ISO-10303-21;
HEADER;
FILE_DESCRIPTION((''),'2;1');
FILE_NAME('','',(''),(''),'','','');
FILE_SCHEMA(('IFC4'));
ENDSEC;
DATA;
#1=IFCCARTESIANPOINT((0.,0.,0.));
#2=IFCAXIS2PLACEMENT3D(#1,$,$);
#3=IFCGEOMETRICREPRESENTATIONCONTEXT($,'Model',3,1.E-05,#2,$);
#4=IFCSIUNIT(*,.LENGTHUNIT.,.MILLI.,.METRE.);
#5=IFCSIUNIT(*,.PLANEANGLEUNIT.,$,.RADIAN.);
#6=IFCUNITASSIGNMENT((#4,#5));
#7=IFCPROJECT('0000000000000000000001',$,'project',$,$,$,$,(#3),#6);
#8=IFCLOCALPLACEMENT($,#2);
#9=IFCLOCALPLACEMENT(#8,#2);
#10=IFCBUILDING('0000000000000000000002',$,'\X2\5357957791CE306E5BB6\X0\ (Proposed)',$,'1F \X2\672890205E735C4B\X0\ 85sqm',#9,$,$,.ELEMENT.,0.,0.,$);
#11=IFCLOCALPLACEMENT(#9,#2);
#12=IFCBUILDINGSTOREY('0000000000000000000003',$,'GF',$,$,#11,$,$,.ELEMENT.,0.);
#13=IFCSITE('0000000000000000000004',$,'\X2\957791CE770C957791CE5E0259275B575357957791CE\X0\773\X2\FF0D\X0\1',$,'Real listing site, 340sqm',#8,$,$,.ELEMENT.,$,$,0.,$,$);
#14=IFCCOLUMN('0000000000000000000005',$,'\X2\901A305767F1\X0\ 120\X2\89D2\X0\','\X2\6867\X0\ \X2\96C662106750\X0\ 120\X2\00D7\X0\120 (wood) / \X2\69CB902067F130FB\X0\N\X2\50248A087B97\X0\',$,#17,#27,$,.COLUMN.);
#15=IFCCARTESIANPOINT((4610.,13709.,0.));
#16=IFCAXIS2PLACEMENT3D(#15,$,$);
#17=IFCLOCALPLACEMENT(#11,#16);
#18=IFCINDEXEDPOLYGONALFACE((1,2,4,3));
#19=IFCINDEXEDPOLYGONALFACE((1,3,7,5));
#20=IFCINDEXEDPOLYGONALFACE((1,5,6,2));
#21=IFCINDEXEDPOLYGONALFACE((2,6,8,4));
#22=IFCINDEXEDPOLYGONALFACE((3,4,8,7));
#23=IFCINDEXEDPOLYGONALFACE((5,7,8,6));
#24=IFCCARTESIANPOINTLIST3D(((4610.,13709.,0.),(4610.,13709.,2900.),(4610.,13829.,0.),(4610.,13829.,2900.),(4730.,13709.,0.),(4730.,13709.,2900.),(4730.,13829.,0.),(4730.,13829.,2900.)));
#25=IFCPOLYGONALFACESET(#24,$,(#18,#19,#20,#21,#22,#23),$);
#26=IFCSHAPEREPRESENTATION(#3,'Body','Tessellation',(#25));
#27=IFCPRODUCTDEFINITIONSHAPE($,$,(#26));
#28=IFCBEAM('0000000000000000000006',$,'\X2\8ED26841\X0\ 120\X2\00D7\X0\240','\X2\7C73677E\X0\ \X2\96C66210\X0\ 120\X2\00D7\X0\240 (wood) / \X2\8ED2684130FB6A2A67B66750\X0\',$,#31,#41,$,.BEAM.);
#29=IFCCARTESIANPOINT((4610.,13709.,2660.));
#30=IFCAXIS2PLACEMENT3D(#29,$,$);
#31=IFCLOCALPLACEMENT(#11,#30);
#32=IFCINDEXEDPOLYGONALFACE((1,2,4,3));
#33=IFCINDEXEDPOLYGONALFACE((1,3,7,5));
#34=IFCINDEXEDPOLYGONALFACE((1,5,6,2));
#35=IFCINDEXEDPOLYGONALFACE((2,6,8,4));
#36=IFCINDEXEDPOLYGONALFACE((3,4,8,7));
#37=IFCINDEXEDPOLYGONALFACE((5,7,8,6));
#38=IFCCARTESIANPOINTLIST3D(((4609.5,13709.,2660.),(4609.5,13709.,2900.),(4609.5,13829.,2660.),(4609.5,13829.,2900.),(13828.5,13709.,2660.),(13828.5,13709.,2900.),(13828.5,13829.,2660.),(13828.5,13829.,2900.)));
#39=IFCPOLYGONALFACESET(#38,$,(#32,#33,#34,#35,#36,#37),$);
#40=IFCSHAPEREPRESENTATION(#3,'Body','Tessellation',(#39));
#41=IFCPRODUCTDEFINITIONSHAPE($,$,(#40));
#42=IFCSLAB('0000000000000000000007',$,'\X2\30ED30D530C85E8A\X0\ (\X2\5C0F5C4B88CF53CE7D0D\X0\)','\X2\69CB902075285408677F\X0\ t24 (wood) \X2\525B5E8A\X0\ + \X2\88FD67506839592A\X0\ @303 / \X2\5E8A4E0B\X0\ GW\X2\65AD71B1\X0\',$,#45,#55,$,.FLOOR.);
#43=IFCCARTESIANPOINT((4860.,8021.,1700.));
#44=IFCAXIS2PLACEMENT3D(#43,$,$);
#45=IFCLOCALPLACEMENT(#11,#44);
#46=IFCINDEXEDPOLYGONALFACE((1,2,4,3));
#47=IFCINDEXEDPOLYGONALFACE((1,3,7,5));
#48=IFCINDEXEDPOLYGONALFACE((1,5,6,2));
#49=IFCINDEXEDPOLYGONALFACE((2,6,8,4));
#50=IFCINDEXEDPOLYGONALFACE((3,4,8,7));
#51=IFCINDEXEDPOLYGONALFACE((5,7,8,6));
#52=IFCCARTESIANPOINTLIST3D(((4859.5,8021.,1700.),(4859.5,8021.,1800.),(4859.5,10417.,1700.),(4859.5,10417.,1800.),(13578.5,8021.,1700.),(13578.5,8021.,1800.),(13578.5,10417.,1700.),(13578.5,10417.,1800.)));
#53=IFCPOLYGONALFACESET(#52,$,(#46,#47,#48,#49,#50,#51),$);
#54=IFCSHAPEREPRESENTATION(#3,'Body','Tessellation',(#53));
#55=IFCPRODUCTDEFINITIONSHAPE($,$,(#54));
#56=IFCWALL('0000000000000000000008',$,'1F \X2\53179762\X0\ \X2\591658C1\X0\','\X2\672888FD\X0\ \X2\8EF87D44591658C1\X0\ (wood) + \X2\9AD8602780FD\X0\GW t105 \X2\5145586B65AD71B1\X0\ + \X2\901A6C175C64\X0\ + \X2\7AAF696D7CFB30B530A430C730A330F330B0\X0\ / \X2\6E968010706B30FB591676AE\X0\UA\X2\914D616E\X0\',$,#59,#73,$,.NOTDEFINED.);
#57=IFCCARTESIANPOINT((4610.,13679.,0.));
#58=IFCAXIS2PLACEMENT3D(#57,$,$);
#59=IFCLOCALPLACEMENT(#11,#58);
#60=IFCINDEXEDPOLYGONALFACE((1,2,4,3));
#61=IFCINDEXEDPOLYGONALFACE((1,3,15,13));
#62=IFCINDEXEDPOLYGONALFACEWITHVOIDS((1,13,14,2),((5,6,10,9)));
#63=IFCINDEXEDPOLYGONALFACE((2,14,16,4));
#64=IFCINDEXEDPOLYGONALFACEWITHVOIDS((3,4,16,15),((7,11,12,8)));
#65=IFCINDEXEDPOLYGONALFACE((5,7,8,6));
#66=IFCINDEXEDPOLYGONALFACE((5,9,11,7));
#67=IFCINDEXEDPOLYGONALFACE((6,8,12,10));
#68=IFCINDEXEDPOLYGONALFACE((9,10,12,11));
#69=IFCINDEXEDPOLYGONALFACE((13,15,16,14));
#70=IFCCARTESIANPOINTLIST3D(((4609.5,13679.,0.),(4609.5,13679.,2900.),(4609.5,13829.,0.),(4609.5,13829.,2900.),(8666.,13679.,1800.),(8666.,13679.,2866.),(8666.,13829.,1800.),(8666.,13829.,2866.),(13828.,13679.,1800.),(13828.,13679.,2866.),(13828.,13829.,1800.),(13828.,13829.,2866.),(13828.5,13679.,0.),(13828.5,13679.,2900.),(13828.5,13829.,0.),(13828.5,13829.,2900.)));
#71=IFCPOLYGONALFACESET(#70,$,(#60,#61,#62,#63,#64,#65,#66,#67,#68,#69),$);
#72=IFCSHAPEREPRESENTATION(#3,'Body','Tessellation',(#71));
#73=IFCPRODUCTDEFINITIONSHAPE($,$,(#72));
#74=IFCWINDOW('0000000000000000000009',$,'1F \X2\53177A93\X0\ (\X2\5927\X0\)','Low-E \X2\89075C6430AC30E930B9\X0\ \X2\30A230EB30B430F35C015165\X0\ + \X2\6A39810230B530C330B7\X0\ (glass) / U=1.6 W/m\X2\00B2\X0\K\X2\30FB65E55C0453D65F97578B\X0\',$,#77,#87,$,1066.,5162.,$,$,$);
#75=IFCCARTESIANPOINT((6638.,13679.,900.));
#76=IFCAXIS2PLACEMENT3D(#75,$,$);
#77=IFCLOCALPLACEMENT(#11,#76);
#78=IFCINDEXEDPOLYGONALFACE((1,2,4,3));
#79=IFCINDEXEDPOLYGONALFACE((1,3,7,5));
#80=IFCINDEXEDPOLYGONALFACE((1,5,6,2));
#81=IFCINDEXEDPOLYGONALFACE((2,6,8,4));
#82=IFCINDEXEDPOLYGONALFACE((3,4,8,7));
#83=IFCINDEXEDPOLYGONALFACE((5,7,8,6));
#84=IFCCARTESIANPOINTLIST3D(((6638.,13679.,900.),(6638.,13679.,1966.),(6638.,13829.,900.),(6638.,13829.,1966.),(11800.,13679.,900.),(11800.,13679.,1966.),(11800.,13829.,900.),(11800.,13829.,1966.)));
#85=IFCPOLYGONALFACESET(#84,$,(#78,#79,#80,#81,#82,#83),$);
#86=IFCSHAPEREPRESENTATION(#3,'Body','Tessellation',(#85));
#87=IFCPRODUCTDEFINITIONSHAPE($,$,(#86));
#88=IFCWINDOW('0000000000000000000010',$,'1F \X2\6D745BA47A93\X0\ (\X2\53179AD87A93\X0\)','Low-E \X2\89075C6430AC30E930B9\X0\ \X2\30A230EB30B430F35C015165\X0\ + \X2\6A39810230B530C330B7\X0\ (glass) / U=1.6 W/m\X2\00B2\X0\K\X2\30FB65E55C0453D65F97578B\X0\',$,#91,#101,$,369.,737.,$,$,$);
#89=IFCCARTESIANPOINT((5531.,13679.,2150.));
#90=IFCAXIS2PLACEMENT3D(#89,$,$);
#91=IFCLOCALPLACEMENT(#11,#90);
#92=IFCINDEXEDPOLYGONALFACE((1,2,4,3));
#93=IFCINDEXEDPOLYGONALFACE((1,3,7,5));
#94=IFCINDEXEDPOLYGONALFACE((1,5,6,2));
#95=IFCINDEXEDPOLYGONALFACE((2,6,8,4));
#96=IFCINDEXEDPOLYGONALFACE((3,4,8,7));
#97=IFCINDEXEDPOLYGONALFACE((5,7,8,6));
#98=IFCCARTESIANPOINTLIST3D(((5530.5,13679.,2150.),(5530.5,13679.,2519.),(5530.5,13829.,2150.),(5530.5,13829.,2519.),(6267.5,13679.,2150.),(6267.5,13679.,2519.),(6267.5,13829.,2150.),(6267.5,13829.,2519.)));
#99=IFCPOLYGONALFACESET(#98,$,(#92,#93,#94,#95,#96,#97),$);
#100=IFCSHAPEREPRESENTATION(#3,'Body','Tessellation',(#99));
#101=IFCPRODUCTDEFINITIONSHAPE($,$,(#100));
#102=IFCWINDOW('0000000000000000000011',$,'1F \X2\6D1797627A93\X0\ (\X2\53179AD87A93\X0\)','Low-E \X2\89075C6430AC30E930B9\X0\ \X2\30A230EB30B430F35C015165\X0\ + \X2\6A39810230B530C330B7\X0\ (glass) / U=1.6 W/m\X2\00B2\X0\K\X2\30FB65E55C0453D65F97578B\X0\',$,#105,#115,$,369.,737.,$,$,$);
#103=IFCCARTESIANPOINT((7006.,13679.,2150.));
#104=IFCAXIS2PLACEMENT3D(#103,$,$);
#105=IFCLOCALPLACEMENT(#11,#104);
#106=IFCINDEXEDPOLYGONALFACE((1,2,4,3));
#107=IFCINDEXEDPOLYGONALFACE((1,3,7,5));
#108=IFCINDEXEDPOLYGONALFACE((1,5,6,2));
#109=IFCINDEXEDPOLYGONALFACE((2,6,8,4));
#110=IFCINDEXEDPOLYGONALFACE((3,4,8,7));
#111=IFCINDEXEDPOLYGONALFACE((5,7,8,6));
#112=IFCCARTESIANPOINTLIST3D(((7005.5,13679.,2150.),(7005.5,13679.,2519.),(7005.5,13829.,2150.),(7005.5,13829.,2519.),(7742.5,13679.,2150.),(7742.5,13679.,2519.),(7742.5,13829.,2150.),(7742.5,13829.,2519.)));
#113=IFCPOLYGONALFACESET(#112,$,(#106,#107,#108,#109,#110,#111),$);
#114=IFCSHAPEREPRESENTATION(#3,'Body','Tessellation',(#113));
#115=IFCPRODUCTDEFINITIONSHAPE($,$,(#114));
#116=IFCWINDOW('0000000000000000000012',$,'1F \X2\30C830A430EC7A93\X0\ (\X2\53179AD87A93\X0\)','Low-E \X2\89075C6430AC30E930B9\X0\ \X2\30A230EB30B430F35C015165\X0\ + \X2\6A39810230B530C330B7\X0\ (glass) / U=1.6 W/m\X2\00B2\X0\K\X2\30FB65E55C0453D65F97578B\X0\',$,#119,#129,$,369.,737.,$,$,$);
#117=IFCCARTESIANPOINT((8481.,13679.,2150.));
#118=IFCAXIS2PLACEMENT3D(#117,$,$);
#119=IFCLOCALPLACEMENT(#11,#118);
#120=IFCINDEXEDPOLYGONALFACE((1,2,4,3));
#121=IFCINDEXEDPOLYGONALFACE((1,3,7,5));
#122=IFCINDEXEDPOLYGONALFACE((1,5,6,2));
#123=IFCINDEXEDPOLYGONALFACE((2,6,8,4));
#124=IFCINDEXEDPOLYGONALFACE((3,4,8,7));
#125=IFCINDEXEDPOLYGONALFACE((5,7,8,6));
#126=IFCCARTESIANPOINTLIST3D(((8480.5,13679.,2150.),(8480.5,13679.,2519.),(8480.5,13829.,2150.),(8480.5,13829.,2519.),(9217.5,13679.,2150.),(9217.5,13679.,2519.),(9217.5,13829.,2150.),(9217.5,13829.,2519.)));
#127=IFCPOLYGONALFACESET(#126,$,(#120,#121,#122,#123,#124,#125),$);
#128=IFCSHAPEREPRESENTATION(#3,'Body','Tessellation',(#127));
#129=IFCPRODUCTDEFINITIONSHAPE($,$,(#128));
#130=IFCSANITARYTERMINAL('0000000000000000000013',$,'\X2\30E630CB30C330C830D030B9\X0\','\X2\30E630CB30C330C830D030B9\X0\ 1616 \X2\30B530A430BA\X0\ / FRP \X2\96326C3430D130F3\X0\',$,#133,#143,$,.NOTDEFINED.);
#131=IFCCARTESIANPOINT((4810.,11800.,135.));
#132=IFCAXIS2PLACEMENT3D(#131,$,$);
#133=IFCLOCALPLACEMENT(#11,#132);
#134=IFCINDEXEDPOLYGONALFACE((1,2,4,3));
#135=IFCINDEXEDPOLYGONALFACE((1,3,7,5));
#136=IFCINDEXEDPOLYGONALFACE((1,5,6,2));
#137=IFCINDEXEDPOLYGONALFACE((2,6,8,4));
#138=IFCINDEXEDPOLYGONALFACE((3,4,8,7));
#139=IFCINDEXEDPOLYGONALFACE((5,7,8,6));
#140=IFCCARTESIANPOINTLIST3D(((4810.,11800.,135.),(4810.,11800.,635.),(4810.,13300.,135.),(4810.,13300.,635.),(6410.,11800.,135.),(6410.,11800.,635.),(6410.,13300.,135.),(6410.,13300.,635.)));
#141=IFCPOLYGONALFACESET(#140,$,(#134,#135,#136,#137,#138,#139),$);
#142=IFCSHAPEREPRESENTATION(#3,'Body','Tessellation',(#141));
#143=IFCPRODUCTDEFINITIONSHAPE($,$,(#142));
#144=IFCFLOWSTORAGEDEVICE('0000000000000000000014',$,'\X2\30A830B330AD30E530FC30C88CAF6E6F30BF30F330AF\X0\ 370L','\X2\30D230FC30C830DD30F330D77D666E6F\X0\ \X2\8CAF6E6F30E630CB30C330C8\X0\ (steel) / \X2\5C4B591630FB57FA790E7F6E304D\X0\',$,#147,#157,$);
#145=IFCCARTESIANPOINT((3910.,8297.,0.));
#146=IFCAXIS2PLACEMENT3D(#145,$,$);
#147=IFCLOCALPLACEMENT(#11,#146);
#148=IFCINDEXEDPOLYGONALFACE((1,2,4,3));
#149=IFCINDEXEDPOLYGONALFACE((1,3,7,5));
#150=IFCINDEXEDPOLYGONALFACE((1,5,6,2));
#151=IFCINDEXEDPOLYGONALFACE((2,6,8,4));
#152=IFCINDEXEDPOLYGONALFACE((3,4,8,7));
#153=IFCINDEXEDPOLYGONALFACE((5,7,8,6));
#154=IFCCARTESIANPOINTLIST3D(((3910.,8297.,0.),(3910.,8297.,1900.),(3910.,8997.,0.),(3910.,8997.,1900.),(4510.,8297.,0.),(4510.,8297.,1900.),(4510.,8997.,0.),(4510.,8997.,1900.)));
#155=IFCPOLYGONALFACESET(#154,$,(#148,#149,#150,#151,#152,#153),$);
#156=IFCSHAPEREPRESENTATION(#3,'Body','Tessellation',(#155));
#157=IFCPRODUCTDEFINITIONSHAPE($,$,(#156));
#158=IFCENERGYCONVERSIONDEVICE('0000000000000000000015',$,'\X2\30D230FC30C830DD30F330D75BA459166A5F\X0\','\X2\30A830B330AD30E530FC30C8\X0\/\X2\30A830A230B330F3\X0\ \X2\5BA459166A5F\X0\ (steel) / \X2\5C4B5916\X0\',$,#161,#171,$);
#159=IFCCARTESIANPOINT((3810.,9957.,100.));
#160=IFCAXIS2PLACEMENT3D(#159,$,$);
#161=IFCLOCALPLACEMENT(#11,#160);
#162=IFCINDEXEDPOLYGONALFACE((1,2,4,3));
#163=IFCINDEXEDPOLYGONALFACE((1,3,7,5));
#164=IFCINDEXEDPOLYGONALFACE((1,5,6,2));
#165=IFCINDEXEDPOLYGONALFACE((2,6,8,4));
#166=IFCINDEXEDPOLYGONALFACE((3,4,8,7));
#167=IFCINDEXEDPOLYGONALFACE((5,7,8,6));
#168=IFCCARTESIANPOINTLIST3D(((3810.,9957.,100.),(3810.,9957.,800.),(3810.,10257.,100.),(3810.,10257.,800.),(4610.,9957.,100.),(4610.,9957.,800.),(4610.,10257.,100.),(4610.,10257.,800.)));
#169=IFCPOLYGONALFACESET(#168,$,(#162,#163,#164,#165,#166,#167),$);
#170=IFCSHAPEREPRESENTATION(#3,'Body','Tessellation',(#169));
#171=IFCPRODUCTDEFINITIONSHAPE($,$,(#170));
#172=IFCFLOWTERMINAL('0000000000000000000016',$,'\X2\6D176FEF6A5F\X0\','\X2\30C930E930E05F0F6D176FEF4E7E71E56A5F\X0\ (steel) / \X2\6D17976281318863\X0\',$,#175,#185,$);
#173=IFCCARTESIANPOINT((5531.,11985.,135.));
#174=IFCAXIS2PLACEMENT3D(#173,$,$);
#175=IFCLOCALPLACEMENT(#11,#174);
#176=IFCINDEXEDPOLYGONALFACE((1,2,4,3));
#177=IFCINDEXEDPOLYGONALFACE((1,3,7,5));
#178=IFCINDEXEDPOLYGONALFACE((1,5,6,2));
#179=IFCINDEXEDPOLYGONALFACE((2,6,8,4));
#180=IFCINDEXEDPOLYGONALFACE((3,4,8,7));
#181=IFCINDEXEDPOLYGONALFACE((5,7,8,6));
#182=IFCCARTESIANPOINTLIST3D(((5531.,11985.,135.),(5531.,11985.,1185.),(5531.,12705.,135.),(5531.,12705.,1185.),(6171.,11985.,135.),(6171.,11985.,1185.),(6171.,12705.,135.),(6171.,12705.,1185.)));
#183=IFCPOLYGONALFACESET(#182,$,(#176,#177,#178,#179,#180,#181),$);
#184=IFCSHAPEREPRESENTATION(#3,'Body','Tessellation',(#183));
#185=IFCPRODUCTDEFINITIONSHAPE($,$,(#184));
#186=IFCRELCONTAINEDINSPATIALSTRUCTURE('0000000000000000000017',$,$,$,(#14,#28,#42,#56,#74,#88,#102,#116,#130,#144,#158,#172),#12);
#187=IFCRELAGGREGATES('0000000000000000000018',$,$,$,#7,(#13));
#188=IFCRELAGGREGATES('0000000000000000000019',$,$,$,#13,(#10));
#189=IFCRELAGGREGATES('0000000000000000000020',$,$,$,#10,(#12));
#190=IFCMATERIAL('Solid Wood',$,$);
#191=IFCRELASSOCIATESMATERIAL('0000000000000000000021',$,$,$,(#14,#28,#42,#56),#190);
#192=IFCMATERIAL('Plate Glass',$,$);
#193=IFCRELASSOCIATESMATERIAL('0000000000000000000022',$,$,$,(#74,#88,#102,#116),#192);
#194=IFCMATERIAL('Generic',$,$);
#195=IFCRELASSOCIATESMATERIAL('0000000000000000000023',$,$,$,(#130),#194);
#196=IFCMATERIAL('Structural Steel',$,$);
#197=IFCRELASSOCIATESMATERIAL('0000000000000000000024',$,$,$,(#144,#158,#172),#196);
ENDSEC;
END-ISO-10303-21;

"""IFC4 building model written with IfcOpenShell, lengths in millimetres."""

from ifc_helpers import new_model, si_unit, frame, frame_2d, origin, place, context, project, spatial, rectangle, extrude, material, element, fill, save


model = new_model("IFC4")

# Units and contexts
model_context = context("Model", 3, precision=1e-05, world=origin())
ifc_project = project(units=[si_unit("LENGTHUNIT", "METRE", prefix="MILLI"), si_unit("PLANEANGLEUNIT", "RADIAN")], contexts=[model_context])

# Site, building, storey
site_placement = place(None, origin())
site = spatial("IfcSite", under=ifc_project, at=site_placement, Name="長野県長野市大字南長野773－1", ObjectType="Real listing site, 340sqm", CompositionType="ELEMENT", RefElevation=0.0)
building_placement = place(site_placement, origin())
building = spatial("IfcBuilding", under=site, at=building_placement, Name="南長野の家 (Proposed)", ObjectType="1F 木造平屋 85sqm", CompositionType="ELEMENT", ElevationOfRefHeight=0.0, ElevationOfTerrain=0.0)
storey_placement = place(building_placement, origin())
storey = spatial("IfcBuildingStorey", under=building, at=storey_placement, Name="GF", CompositionType="ELEMENT", Elevation=0.0)

# Column
ifc_material_1 = material(Name="Solid Wood")
column_1_placement = place(storey_placement, frame((4610.0, 13709.0, 0.0)))
element("IfcColumn", 1, at=column_1_placement, inside=storey, material=ifc_material_1, Name="通し柱 120角", Description="桧 集成材 120×120 (wood) / 構造柱・N値計算", PredefinedType="COLUMN", context=model_context, shape_type="SweptSolid", body=[
    extrude(rectangle(XDim=120.0, YDim=120.0, at=frame_2d((60.0, 60.0))), frame((4610.0, 13709.0, 0.0)), (0.0, 0.0, 1.0), 2900.0),
])

# Beam
beam_1_placement = place(storey_placement, frame((4610.0, 13709.0, 2660.0)))
element("IfcBeam", 2, at=beam_1_placement, inside=storey, material=ifc_material_1, Name="軒桁 120×240", Description="米松 集成 120×240 (wood) / 軒桁・横架材", PredefinedType="BEAM", context=model_context, shape_type="SweptSolid", body=[
    extrude(rectangle(XDim=9219.0, YDim=120.0, at=frame_2d((4609.0, 60.0))), frame((4610.0, 13709.0, 2660.0)), (0.0, 0.0, 1.0), 240.0),
])

# Slab
slab_placement = place(storey_placement, frame((4860.0, 8021.0, 1700.0)))
element("IfcSlab", 3, at=slab_placement, inside=storey, material=ifc_material_1, Name="ロフト床 (小屋裏収納)", Description="構造用合板 t24 (wood) 剛床 + 製材根太 @303 / 床下 GW断熱", PredefinedType="FLOOR", context=model_context, shape_type="SweptSolid", body=[
    extrude(rectangle(XDim=8719.0, YDim=2396.0, at=frame_2d((4359.0, 1198.0))), frame((4860.0, 8021.0, 1700.0)), (0.0, 0.0, 1.0), 100.0),
])

# Wall, openings, windows
wall_1_placement = place(storey_placement, frame((4610.0, 13679.0, 0.0)))
wall_1 = element("IfcWall", 4, at=wall_1_placement, inside=storey, material=ifc_material_1, Name="1F 北面 外壁", Description="木製 軸組外壁 (wood) + 高性能GW t105 充填断熱 + 通気層 + 窯業系サイディング / 準耐火・外皮UA配慮", PredefinedType="NOTDEFINED", context=model_context, shape_type="SweptSolid", body=[
    extrude(rectangle(XDim=9219.0, YDim=150.0, at=frame_2d((4609.0, 75.0))), frame((4610.0, 13679.0, 0.0)), (0.0, 0.0, 1.0), 2900.0),
])
opening_1_placement = place(storey_placement, frame((6638.0, 13679.0, 900.0)))
opening_1 = element("IfcOpeningElement", 5, at=opening_1_placement, cuts=wall_1, PredefinedType="NOTDEFINED", context=model_context, shape_type="SweptSolid", body=[
    extrude(rectangle(XDim=5162.0, YDim=150.0, at=frame_2d((2581.0, 75.0))), frame((6638.0, 13679.0, 900.0)), (0.0, 0.0, 1.0), 1066.0),
])
opening_2_placement = place(storey_placement, frame((5531.0, 13679.0, 2150.0)))
opening_2 = element("IfcOpeningElement", 6, at=opening_2_placement, cuts=wall_1, PredefinedType="NOTDEFINED", context=model_context, shape_type="SweptSolid", body=[
    extrude(rectangle(XDim=737.0, YDim=150.0, at=frame_2d((368.0, 75.0))), frame((5531.0, 13679.0, 2150.0)), (0.0, 0.0, 1.0), 369.0),
])
opening_3_placement = place(storey_placement, frame((7006.0, 13679.0, 2150.0)))
opening_3 = element("IfcOpeningElement", 7, at=opening_3_placement, cuts=wall_1, PredefinedType="NOTDEFINED", context=model_context, shape_type="SweptSolid", body=[
    extrude(rectangle(XDim=737.0, YDim=150.0, at=frame_2d((368.0, 75.0))), frame((7006.0, 13679.0, 2150.0)), (0.0, 0.0, 1.0), 369.0),
])
opening_4_placement = place(storey_placement, frame((8481.0, 13679.0, 2150.0)))
opening_4 = element("IfcOpeningElement", 8, at=opening_4_placement, cuts=wall_1, PredefinedType="NOTDEFINED", context=model_context, shape_type="SweptSolid", body=[
    extrude(rectangle(XDim=737.0, YDim=150.0, at=frame_2d((368.0, 75.0))), frame((8481.0, 13679.0, 2150.0)), (0.0, 0.0, 1.0), 369.0),
])
ifc_material_2 = material(Name="Plate Glass")
window_1_placement = place(storey_placement, frame((6638.0, 13679.0, 900.0)))
window_1 = element("IfcWindow", 9, at=window_1_placement, inside=storey, material=ifc_material_2, Name="1F 北窓 (大)", Description="Low-E 複層ガラス アルゴン封入 + 樹脂サッシ (glass) / U=1.6 W/m²K・日射取得型", OverallHeight=1066.0, OverallWidth=5162.0, context=model_context, shape_type="SweptSolid", body=[
    extrude(rectangle(XDim=5162.0, YDim=150.0, at=frame_2d((2581.0, 75.0))), frame((6638.0, 13679.0, 900.0)), (0.0, 0.0, 1.0), 1066.0),
])
fill(opening_1, window_1)
window_2_placement = place(storey_placement, frame((5531.0, 13679.0, 2150.0)))
window_2 = element("IfcWindow", 10, at=window_2_placement, inside=storey, material=ifc_material_2, Name="1F 浴室窓 (北高窓)", Description="Low-E 複層ガラス アルゴン封入 + 樹脂サッシ (glass) / U=1.6 W/m²K・日射取得型", OverallHeight=369.0, OverallWidth=737.0, context=model_context, shape_type="SweptSolid", body=[
    extrude(rectangle(XDim=737.0, YDim=150.0, at=frame_2d((368.0, 75.0))), frame((5531.0, 13679.0, 2150.0)), (0.0, 0.0, 1.0), 369.0),
])
fill(opening_2, window_2)
window_3_placement = place(storey_placement, frame((7006.0, 13679.0, 2150.0)))
window_3 = element("IfcWindow", 11, at=window_3_placement, inside=storey, material=ifc_material_2, Name="1F 洗面窓 (北高窓)", Description="Low-E 複層ガラス アルゴン封入 + 樹脂サッシ (glass) / U=1.6 W/m²K・日射取得型", OverallHeight=369.0, OverallWidth=737.0, context=model_context, shape_type="SweptSolid", body=[
    extrude(rectangle(XDim=737.0, YDim=150.0, at=frame_2d((368.0, 75.0))), frame((7006.0, 13679.0, 2150.0)), (0.0, 0.0, 1.0), 369.0),
])
fill(opening_3, window_3)
window_4_placement = place(storey_placement, frame((8481.0, 13679.0, 2150.0)))
window_4 = element("IfcWindow", 12, at=window_4_placement, inside=storey, material=ifc_material_2, Name="1F トイレ窓 (北高窓)", Description="Low-E 複層ガラス アルゴン封入 + 樹脂サッシ (glass) / U=1.6 W/m²K・日射取得型", OverallHeight=369.0, OverallWidth=737.0, context=model_context, shape_type="SweptSolid", body=[
    extrude(rectangle(XDim=737.0, YDim=150.0, at=frame_2d((368.0, 75.0))), frame((8481.0, 13679.0, 2150.0)), (0.0, 0.0, 1.0), 369.0),
])
fill(opening_4, window_4)

# Sanitary terminal
ifc_material_3 = material(Name="Generic")
sanitary_terminal_placement = place(storey_placement, frame((4810.0, 11800.0, 135.0)))
element("IfcSanitaryTerminal", 13, at=sanitary_terminal_placement, inside=storey, material=ifc_material_3, Name="ユニットバス", Description="ユニットバス 1616 サイズ / FRP 防水パン", PredefinedType="NOTDEFINED", context=model_context, shape_type="SweptSolid", body=[
    extrude(rectangle(XDim=1600.0, YDim=1500.0, at=frame_2d((800.0, 750.0))), frame((4810.0, 11800.0, 135.0)), (0.0, 0.0, 1.0), 500.0),
])

# Flow storage device
ifc_material_4 = material(Name="Structural Steel")
flow_storage_device_placement = place(storey_placement, frame((3910.0, 8297.0, 0.0)))
element("IfcFlowStorageDevice", 14, at=flow_storage_device_placement, inside=storey, material=ifc_material_4, Name="エコキュート貯湯タンク 370L", Description="ヒートポンプ給湯 貯湯ユニット (steel) / 屋外・基礎置き", context=model_context, shape_type="SweptSolid", body=[
    extrude(rectangle(XDim=600.0, YDim=700.0, at=frame_2d((300.0, 350.0))), frame((3910.0, 8297.0, 0.0)), (0.0, 0.0, 1.0), 1900.0),
])

# Energy conversion device
energy_conversion_device_placement = place(storey_placement, frame((3810.0, 9957.0, 100.0)))
element("IfcEnergyConversionDevice", 15, at=energy_conversion_device_placement, inside=storey, material=ifc_material_4, Name="ヒートポンプ室外機", Description="エコキュート/エアコン 室外機 (steel) / 屋外", context=model_context, shape_type="SweptSolid", body=[
    extrude(rectangle(XDim=800.0, YDim=300.0, at=frame_2d((400.0, 150.0))), frame((3810.0, 9957.0, 100.0)), (0.0, 0.0, 1.0), 700.0),
])

# Flow terminal
flow_terminal_placement = place(storey_placement, frame((5531.0, 11985.0, 135.0)))
element("IfcFlowTerminal", 16, at=flow_terminal_placement, inside=storey, material=ifc_material_4, Name="洗濯機", Description="ドラム式洗濯乾燥機 (steel) / 洗面脱衣", context=model_context, shape_type="SweptSolid", body=[
    extrude(rectangle(XDim=640.0, YDim=720.0, at=frame_2d((320.0, 360.0))), frame((5531.0, 11985.0, 135.0)), (0.0, 0.0, 1.0), 1050.0),
])

save(model, "model.ifc")
